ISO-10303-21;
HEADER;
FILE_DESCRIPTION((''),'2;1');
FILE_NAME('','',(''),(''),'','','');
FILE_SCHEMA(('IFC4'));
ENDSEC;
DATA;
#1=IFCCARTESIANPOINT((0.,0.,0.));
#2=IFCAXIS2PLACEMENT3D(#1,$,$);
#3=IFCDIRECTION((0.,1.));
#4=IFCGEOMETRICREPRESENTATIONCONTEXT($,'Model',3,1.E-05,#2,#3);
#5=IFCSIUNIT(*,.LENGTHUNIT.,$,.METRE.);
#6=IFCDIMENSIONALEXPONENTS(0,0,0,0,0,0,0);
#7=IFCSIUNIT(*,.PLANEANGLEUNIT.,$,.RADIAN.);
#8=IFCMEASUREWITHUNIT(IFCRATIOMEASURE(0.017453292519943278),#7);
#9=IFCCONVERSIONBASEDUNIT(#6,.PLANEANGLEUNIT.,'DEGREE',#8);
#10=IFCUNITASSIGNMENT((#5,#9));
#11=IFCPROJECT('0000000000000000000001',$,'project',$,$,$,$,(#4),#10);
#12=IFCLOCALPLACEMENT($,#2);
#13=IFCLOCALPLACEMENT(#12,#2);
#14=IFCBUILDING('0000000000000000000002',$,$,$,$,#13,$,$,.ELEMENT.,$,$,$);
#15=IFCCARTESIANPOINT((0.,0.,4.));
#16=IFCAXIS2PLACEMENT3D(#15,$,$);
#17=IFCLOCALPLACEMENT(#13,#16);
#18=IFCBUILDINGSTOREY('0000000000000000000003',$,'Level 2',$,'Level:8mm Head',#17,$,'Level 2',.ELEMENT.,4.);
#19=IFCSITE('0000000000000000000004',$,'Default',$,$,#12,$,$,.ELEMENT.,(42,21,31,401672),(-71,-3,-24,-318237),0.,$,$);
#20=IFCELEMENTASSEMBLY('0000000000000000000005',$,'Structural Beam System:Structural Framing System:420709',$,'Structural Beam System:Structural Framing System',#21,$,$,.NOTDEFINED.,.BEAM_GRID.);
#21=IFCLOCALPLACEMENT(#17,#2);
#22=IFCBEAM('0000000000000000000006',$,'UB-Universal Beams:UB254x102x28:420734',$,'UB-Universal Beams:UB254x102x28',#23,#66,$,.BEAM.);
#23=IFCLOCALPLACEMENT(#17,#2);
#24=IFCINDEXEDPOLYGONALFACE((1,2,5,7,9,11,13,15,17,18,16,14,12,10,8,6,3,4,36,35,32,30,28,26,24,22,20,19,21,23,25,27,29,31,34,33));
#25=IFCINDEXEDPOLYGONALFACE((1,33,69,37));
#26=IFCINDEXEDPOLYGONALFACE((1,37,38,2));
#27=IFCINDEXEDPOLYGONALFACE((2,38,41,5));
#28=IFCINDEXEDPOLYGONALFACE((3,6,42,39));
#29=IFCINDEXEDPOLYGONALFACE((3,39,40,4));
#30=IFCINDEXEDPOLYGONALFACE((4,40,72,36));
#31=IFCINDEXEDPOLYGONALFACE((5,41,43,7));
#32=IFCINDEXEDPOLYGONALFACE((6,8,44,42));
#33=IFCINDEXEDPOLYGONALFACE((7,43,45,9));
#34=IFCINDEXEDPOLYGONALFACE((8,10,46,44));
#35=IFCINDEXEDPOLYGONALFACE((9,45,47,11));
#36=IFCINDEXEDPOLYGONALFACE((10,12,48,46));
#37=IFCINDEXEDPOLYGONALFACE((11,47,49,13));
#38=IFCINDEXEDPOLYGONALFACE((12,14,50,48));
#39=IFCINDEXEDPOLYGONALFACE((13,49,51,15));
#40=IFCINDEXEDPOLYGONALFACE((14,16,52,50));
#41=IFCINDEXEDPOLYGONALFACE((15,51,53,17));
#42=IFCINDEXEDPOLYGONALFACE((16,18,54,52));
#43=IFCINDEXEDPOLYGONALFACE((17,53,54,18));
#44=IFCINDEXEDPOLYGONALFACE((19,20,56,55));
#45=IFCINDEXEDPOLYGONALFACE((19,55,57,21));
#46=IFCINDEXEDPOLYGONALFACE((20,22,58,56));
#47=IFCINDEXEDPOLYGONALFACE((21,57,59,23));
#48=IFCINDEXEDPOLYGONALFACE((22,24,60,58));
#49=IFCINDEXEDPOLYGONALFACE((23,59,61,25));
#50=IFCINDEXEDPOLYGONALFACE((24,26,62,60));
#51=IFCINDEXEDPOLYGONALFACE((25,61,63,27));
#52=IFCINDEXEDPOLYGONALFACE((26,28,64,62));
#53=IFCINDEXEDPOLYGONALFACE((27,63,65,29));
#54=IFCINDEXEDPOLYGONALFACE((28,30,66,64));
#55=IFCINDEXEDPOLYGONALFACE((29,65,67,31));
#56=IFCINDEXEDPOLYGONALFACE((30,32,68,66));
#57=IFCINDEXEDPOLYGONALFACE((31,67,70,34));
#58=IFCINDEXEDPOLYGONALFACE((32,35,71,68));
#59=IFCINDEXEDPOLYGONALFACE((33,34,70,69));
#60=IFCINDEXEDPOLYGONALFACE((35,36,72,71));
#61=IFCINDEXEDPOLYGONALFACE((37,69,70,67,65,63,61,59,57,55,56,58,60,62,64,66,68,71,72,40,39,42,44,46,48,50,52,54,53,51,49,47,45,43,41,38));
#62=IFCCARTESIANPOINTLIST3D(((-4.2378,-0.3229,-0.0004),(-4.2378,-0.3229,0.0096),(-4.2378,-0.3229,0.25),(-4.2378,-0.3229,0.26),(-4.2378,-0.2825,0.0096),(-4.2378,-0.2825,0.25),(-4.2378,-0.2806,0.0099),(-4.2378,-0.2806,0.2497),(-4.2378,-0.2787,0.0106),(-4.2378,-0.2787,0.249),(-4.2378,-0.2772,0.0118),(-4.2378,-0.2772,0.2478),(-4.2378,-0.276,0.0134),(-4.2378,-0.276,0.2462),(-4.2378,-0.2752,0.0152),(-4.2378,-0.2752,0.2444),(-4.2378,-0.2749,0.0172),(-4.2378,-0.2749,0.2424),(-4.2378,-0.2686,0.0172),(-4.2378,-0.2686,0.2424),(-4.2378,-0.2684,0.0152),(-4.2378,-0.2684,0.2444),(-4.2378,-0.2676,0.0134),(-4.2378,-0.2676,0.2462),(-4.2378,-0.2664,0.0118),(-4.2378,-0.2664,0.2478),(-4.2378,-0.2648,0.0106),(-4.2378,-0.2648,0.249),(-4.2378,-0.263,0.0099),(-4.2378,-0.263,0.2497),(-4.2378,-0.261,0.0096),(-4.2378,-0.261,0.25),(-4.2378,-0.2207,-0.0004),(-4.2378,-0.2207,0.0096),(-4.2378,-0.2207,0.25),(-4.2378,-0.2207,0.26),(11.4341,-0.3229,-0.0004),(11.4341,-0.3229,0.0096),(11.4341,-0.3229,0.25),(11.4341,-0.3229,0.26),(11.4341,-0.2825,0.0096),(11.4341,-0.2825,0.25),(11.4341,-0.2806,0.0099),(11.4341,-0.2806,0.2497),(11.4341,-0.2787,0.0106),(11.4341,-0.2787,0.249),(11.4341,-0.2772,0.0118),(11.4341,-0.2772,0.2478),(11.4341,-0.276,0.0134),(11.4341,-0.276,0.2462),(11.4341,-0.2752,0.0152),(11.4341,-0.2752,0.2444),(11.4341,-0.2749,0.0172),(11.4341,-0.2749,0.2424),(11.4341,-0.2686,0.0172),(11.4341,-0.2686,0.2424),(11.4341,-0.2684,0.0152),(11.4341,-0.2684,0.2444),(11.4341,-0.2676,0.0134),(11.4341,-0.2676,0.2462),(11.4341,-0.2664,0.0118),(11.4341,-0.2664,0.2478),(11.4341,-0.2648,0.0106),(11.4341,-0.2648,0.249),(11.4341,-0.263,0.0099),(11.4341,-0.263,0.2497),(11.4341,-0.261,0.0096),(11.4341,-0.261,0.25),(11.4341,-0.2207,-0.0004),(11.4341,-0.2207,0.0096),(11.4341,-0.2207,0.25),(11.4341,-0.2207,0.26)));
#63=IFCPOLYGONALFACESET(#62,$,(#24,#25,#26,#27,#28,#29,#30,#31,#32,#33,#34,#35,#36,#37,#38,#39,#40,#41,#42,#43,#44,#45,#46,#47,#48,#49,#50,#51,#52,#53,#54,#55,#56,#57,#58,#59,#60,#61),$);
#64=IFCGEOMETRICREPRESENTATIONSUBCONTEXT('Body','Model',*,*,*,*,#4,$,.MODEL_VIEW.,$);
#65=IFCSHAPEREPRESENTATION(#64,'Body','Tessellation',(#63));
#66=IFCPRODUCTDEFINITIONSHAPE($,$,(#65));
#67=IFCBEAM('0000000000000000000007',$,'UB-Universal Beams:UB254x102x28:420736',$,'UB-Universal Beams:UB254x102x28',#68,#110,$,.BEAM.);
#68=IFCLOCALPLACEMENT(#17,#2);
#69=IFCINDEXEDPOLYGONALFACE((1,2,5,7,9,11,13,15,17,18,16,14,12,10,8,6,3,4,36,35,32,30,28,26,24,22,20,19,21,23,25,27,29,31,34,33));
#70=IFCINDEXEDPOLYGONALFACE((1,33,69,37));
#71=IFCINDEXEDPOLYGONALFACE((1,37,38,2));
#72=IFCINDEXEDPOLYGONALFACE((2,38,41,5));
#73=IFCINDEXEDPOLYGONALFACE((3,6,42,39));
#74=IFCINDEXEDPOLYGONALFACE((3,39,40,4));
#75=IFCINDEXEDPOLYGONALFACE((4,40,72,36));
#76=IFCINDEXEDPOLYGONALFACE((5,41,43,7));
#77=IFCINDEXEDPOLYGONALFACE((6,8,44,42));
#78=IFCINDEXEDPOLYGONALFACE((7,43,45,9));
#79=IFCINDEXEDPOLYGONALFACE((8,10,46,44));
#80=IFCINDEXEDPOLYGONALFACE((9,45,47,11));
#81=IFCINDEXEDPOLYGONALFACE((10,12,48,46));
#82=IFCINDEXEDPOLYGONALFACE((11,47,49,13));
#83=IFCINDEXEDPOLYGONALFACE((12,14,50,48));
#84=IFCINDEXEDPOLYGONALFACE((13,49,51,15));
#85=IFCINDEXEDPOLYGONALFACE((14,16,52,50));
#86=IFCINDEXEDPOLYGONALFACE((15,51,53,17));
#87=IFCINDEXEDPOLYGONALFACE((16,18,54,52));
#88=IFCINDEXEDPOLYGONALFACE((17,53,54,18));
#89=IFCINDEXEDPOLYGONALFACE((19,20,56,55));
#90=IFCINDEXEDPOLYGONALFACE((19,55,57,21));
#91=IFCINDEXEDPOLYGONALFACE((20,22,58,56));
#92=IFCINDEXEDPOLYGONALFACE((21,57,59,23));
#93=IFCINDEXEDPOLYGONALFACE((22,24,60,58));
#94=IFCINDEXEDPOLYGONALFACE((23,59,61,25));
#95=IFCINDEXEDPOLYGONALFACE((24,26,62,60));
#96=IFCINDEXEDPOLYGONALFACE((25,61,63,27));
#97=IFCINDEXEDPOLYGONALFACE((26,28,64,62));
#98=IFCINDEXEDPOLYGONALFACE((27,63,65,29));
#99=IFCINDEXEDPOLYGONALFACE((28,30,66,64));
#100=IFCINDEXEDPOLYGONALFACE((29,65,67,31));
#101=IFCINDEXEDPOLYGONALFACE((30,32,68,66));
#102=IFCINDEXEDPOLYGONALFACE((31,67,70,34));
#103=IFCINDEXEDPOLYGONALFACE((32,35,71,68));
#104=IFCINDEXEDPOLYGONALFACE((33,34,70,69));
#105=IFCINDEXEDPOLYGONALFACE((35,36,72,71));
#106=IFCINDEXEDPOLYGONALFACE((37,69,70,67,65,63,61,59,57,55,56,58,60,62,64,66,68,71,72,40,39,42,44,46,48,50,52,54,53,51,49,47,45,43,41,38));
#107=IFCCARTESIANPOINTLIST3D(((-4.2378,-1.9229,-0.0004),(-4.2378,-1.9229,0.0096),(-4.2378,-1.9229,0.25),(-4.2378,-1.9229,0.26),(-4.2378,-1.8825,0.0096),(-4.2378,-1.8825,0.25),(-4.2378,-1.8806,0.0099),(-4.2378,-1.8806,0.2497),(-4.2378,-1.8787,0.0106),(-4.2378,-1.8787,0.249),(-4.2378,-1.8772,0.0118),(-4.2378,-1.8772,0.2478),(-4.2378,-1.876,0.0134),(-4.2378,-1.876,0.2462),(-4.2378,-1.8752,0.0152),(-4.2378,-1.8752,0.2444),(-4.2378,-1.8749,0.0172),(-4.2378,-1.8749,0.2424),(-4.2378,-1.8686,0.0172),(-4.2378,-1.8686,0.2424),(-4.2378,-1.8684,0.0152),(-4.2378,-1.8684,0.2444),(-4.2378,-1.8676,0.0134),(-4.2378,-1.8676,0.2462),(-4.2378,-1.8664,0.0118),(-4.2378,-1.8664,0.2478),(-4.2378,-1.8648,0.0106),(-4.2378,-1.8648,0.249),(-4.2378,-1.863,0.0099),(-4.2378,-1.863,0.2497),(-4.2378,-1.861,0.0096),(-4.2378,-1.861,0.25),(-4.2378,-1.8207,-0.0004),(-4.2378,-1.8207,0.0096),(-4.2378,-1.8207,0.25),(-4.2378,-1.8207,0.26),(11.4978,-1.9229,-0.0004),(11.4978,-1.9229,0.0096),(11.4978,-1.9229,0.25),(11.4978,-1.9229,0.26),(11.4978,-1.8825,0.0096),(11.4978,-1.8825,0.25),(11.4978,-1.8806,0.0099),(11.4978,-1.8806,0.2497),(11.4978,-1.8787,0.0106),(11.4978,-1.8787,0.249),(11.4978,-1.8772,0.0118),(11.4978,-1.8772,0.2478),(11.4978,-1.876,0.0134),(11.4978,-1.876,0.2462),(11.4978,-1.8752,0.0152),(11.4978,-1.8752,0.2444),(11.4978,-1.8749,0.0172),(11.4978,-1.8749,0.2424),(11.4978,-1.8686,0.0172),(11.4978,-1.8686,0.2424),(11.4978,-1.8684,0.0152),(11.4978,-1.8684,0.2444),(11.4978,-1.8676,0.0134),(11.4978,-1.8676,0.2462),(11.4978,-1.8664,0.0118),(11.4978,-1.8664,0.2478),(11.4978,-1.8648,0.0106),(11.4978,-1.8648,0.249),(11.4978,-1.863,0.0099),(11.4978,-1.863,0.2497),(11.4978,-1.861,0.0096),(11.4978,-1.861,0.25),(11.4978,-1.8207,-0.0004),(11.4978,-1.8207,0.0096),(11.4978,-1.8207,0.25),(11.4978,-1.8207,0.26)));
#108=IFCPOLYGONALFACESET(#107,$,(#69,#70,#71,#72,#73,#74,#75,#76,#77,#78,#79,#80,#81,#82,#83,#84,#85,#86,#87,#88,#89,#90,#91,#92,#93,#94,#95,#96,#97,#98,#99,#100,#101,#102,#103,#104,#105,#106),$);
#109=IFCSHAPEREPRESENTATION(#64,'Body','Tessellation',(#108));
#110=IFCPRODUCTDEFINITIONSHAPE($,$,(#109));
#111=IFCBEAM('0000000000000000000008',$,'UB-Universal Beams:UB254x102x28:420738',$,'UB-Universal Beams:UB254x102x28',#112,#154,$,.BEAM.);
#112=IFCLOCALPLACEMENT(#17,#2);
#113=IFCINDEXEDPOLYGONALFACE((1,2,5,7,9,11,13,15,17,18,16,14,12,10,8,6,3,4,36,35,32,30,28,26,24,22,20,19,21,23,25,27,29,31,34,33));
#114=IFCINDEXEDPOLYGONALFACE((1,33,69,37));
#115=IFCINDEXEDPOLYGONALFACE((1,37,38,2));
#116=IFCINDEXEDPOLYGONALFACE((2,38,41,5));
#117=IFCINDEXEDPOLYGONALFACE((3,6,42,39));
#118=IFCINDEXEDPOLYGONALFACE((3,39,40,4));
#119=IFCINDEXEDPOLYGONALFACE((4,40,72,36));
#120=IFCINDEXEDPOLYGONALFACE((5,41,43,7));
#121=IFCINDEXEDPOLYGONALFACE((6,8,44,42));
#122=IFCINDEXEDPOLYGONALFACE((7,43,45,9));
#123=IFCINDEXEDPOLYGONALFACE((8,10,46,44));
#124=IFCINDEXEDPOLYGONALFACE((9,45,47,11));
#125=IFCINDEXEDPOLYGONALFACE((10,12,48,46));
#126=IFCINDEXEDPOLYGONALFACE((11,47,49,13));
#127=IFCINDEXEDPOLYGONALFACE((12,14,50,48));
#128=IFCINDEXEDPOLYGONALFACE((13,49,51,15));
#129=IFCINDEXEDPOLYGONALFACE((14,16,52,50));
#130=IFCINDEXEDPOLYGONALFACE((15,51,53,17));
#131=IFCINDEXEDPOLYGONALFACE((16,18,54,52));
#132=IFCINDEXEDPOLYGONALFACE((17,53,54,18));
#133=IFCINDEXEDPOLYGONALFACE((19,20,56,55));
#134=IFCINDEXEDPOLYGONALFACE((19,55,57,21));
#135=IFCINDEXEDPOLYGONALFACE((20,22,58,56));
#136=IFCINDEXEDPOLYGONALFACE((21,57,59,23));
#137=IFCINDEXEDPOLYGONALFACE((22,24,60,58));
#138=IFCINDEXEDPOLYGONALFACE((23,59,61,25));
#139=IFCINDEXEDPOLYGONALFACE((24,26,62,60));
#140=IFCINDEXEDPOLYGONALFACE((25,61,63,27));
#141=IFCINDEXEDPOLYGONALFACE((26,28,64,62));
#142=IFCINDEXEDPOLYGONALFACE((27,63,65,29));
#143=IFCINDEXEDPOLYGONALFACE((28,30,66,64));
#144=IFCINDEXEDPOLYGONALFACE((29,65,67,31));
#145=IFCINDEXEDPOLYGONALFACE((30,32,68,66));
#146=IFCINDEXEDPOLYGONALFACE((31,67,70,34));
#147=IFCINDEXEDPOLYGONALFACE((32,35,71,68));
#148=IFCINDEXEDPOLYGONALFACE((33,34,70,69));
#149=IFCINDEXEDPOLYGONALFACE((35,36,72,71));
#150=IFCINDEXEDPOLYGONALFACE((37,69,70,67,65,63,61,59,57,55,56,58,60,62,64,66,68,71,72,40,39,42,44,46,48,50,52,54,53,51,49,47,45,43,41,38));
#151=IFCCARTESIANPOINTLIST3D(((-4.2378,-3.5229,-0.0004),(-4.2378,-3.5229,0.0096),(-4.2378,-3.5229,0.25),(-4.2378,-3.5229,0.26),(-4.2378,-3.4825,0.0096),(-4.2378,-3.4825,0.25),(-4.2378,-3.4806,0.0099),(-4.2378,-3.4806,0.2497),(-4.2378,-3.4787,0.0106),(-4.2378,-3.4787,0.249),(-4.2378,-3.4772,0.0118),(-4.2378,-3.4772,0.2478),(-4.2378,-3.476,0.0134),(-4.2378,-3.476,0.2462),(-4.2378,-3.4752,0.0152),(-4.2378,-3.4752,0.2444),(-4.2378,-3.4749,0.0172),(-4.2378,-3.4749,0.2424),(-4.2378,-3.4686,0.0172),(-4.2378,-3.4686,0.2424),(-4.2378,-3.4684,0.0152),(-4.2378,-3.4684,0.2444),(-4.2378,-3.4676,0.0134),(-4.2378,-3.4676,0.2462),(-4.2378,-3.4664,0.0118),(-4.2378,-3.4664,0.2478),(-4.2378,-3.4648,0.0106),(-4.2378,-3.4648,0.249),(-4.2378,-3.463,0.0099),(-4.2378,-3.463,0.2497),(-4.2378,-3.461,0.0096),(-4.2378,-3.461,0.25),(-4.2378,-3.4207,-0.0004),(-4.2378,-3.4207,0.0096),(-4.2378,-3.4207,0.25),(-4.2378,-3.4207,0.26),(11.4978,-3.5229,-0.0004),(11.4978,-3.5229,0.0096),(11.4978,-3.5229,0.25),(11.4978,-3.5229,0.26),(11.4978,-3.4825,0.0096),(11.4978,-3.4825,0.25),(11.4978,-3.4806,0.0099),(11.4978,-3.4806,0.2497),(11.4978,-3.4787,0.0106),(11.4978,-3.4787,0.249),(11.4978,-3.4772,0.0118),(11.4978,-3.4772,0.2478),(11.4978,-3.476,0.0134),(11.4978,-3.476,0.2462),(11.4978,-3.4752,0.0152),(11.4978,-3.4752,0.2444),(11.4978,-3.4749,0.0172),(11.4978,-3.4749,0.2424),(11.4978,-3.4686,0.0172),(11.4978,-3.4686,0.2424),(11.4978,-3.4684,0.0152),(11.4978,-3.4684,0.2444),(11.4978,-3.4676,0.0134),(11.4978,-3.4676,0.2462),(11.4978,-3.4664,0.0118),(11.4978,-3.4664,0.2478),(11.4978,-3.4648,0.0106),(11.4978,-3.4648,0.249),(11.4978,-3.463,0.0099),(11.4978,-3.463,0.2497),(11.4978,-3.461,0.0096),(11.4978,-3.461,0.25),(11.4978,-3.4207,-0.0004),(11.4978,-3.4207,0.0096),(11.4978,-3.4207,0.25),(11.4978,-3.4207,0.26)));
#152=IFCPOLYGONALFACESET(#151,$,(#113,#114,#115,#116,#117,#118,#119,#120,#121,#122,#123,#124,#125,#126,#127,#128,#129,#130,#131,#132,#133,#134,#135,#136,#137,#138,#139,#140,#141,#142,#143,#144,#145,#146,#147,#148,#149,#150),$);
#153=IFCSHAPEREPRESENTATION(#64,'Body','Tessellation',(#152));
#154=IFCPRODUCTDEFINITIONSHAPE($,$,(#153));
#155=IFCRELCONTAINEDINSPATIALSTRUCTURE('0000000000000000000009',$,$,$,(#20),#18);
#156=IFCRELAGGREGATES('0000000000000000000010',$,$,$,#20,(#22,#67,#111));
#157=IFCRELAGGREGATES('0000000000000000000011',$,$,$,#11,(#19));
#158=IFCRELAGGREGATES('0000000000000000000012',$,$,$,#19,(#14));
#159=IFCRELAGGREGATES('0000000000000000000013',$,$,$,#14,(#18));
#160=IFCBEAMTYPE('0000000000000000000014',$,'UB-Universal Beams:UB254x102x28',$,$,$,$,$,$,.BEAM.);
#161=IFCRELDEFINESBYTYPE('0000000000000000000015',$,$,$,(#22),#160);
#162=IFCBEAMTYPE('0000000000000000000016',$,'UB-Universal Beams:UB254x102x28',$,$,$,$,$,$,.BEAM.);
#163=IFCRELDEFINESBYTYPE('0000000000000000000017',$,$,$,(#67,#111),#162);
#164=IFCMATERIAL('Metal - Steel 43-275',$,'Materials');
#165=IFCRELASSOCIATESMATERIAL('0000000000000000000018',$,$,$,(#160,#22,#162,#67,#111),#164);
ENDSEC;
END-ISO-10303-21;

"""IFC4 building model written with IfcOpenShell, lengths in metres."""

from ifc_helpers import new_model, entity, si_unit, converted_unit, direction, frame, origin, place, context, subcontext, project, spatial, line, arc, indexed_curve, outline, extrude, source, transform, mapped, material, type_object, type_shapes, element, aggregate, save


model = new_model("IFC4")

# Units and contexts
model_context = context("Model", 3, precision=1e-05, world=origin(), true_north=direction((0.0, 1.0)))
body_context = subcontext(model_context, "Body", "Model", "MODEL_VIEW")
ifc_project = project(units=[si_unit("LENGTHUNIT", "METRE"), converted_unit("PLANEANGLEUNIT", "DEGREE", entity("IfcRatioMeasure", 0.017453292519943278), si_unit("PLANEANGLEUNIT", "RADIAN"), dimensions=[0, 0, 0, 0, 0, 0, 0])], contexts=[model_context])

# Site, building, storey
site_placement = place(None, origin())
site = spatial("IfcSite", under=ifc_project, at=site_placement, Name="Default", CompositionType="ELEMENT", RefLatitude=(42, 21, 31, 401672), RefLongitude=(-71, -3, -24, -318237), RefElevation=0.0)
building_placement = place(site_placement, origin())
building = spatial("IfcBuilding", under=site, at=building_placement, CompositionType="ELEMENT")
storey_placement = place(building_placement, frame((0.0, 0.0, 4.0)))
storey = spatial("IfcBuildingStorey", under=building, at=storey_placement, Name="Level 2", ObjectType="Level:8mm Head", LongName="Level 2", CompositionType="ELEMENT", Elevation=4.0)

# Shared definitions
ifc_material_1 = material(Name="Metal - Steel 43-275", Category="Materials")

# Element assembly, beams
assembly_placement = place(storey_placement, origin())
assembly = element("IfcElementAssembly", 1, at=assembly_placement, inside=storey, Name="Structural Beam System:Structural Framing System:420709", ObjectType="Structural Beam System:Structural Framing System", AssemblyPlace="NOTDEFINED", PredefinedType="BEAM_GRID")
beam_type_1 = type_object("IfcBeamType", Name="UB-Universal Beams:UB254x102x28", PredefinedType="BEAM", material=ifc_material_1)
shared_shape_1 = source(origin(), body_context, "Body", "SweptSolid", [
    extrude(outline(indexed_curve([(-0.1302, -0.0511), (-0.1202, -0.0511), (-0.1202, -0.0107), (-0.118, -0.0054), (-0.1126, -0.0031), (0.1126, -0.0031), (0.118, -0.0054), (0.1202, -0.0107), (0.1202, -0.0511), (0.1302, -0.0511), (0.1302, 0.0511), (0.1202, 0.0511), (0.1202, 0.0108), (0.118, 0.0054), (0.1126, 0.0032), (-0.1126, 0.0032), (-0.118, 0.0054), (-0.1202, 0.0108), (-0.1202, 0.0511), (-0.1302, 0.0511)], segments=[line(1, 2, 3), arc(3, 4, 5), line(5, 6), arc(6, 7, 8), line(8, 9, 10, 11, 12, 13), arc(13, 14, 15), line(15, 16), arc(16, 17, 18), line(18, 19, 20, 1)], self_intersect=False)), frame((-7.8818, 0.0, 0.0), z_axis=(1.0, 0.0, 0.0), x_axis=(0.0, 0.0, -1.0)), (0.0, 0.0, 1.0), 15.6719),
])
type_shapes(beam_type_1, [shared_shape_1])
beam_1_placement = place(assembly_placement, frame((3.644, -0.2718, 0.1298)))
beam_1 = element("IfcBeam", 2, at=beam_1_placement, type_object=beam_type_1, material=ifc_material_1, Name="UB-Universal Beams:UB254x102x28:420734", ObjectType="UB-Universal Beams:UB254x102x28", PredefinedType="BEAM", context=body_context, shape_type="MappedRepresentation", body=[
    mapped(shared_shape_1, transform((0.0, 0.0, 0.0), scale=1.0)),
])
beam_type_2 = type_object("IfcBeamType", Name="UB-Universal Beams:UB254x102x28", PredefinedType="BEAM", material=ifc_material_1)
shared_shape_2 = source(origin(), body_context, "Body", "SweptSolid", [
    extrude(outline(indexed_curve([(-0.1302, -0.0511), (-0.1202, -0.0511), (-0.1202, -0.0107), (-0.118, -0.0054), (-0.1126, -0.0031), (0.1126, -0.0031), (0.118, -0.0054), (0.1202, -0.0107), (0.1202, -0.0511), (0.1302, -0.0511), (0.1302, 0.0511), (0.1202, 0.0511), (0.1202, 0.0108), (0.118, 0.0054), (0.1126, 0.0032), (-0.1126, 0.0032), (-0.118, 0.0054), (-0.1202, 0.0108), (-0.1202, 0.0511), (-0.1302, 0.0511)], segments=[line(1, 2, 3), arc(3, 4, 5), line(5, 6), arc(6, 7, 8), line(8, 9, 10, 11, 12, 13), arc(13, 14, 15), line(15, 16), arc(16, 17, 18), line(18, 19, 20, 1)], self_intersect=False)), frame((-7.8373, 0.0, 0.0), z_axis=(1.0, 0.0, 0.0), x_axis=(0.0, 0.0, -1.0)), (0.0, 0.0, 1.0), 15.7356),
])
type_shapes(beam_type_2, [shared_shape_2])
beam_2_placement = place(assembly_placement, frame((3.5995, -1.8718, 0.1298)))
beam_2 = element("IfcBeam", 3, at=beam_2_placement, type_object=beam_type_2, material=ifc_material_1, Name="UB-Universal Beams:UB254x102x28:420736", ObjectType="UB-Universal Beams:UB254x102x28", PredefinedType="BEAM", context=body_context, shape_type="MappedRepresentation", body=[
    mapped(shared_shape_2, transform((0.0, 0.0, 0.0), scale=1.0)),
])
beam_3_placement = place(assembly_placement, frame((3.5995, -3.4718, 0.1298)))
beam_3 = element("IfcBeam", 4, at=beam_3_placement, type_object=beam_type_2, material=ifc_material_1, Name="UB-Universal Beams:UB254x102x28:420738", ObjectType="UB-Universal Beams:UB254x102x28", PredefinedType="BEAM", context=body_context, shape_type="MappedRepresentation", body=[
    mapped(shared_shape_2, transform((0.0, 0.0, 0.0), scale=1.0)),
])
aggregate(assembly, [beam_1, beam_2, beam_3])

save(model, "model.ifc")
